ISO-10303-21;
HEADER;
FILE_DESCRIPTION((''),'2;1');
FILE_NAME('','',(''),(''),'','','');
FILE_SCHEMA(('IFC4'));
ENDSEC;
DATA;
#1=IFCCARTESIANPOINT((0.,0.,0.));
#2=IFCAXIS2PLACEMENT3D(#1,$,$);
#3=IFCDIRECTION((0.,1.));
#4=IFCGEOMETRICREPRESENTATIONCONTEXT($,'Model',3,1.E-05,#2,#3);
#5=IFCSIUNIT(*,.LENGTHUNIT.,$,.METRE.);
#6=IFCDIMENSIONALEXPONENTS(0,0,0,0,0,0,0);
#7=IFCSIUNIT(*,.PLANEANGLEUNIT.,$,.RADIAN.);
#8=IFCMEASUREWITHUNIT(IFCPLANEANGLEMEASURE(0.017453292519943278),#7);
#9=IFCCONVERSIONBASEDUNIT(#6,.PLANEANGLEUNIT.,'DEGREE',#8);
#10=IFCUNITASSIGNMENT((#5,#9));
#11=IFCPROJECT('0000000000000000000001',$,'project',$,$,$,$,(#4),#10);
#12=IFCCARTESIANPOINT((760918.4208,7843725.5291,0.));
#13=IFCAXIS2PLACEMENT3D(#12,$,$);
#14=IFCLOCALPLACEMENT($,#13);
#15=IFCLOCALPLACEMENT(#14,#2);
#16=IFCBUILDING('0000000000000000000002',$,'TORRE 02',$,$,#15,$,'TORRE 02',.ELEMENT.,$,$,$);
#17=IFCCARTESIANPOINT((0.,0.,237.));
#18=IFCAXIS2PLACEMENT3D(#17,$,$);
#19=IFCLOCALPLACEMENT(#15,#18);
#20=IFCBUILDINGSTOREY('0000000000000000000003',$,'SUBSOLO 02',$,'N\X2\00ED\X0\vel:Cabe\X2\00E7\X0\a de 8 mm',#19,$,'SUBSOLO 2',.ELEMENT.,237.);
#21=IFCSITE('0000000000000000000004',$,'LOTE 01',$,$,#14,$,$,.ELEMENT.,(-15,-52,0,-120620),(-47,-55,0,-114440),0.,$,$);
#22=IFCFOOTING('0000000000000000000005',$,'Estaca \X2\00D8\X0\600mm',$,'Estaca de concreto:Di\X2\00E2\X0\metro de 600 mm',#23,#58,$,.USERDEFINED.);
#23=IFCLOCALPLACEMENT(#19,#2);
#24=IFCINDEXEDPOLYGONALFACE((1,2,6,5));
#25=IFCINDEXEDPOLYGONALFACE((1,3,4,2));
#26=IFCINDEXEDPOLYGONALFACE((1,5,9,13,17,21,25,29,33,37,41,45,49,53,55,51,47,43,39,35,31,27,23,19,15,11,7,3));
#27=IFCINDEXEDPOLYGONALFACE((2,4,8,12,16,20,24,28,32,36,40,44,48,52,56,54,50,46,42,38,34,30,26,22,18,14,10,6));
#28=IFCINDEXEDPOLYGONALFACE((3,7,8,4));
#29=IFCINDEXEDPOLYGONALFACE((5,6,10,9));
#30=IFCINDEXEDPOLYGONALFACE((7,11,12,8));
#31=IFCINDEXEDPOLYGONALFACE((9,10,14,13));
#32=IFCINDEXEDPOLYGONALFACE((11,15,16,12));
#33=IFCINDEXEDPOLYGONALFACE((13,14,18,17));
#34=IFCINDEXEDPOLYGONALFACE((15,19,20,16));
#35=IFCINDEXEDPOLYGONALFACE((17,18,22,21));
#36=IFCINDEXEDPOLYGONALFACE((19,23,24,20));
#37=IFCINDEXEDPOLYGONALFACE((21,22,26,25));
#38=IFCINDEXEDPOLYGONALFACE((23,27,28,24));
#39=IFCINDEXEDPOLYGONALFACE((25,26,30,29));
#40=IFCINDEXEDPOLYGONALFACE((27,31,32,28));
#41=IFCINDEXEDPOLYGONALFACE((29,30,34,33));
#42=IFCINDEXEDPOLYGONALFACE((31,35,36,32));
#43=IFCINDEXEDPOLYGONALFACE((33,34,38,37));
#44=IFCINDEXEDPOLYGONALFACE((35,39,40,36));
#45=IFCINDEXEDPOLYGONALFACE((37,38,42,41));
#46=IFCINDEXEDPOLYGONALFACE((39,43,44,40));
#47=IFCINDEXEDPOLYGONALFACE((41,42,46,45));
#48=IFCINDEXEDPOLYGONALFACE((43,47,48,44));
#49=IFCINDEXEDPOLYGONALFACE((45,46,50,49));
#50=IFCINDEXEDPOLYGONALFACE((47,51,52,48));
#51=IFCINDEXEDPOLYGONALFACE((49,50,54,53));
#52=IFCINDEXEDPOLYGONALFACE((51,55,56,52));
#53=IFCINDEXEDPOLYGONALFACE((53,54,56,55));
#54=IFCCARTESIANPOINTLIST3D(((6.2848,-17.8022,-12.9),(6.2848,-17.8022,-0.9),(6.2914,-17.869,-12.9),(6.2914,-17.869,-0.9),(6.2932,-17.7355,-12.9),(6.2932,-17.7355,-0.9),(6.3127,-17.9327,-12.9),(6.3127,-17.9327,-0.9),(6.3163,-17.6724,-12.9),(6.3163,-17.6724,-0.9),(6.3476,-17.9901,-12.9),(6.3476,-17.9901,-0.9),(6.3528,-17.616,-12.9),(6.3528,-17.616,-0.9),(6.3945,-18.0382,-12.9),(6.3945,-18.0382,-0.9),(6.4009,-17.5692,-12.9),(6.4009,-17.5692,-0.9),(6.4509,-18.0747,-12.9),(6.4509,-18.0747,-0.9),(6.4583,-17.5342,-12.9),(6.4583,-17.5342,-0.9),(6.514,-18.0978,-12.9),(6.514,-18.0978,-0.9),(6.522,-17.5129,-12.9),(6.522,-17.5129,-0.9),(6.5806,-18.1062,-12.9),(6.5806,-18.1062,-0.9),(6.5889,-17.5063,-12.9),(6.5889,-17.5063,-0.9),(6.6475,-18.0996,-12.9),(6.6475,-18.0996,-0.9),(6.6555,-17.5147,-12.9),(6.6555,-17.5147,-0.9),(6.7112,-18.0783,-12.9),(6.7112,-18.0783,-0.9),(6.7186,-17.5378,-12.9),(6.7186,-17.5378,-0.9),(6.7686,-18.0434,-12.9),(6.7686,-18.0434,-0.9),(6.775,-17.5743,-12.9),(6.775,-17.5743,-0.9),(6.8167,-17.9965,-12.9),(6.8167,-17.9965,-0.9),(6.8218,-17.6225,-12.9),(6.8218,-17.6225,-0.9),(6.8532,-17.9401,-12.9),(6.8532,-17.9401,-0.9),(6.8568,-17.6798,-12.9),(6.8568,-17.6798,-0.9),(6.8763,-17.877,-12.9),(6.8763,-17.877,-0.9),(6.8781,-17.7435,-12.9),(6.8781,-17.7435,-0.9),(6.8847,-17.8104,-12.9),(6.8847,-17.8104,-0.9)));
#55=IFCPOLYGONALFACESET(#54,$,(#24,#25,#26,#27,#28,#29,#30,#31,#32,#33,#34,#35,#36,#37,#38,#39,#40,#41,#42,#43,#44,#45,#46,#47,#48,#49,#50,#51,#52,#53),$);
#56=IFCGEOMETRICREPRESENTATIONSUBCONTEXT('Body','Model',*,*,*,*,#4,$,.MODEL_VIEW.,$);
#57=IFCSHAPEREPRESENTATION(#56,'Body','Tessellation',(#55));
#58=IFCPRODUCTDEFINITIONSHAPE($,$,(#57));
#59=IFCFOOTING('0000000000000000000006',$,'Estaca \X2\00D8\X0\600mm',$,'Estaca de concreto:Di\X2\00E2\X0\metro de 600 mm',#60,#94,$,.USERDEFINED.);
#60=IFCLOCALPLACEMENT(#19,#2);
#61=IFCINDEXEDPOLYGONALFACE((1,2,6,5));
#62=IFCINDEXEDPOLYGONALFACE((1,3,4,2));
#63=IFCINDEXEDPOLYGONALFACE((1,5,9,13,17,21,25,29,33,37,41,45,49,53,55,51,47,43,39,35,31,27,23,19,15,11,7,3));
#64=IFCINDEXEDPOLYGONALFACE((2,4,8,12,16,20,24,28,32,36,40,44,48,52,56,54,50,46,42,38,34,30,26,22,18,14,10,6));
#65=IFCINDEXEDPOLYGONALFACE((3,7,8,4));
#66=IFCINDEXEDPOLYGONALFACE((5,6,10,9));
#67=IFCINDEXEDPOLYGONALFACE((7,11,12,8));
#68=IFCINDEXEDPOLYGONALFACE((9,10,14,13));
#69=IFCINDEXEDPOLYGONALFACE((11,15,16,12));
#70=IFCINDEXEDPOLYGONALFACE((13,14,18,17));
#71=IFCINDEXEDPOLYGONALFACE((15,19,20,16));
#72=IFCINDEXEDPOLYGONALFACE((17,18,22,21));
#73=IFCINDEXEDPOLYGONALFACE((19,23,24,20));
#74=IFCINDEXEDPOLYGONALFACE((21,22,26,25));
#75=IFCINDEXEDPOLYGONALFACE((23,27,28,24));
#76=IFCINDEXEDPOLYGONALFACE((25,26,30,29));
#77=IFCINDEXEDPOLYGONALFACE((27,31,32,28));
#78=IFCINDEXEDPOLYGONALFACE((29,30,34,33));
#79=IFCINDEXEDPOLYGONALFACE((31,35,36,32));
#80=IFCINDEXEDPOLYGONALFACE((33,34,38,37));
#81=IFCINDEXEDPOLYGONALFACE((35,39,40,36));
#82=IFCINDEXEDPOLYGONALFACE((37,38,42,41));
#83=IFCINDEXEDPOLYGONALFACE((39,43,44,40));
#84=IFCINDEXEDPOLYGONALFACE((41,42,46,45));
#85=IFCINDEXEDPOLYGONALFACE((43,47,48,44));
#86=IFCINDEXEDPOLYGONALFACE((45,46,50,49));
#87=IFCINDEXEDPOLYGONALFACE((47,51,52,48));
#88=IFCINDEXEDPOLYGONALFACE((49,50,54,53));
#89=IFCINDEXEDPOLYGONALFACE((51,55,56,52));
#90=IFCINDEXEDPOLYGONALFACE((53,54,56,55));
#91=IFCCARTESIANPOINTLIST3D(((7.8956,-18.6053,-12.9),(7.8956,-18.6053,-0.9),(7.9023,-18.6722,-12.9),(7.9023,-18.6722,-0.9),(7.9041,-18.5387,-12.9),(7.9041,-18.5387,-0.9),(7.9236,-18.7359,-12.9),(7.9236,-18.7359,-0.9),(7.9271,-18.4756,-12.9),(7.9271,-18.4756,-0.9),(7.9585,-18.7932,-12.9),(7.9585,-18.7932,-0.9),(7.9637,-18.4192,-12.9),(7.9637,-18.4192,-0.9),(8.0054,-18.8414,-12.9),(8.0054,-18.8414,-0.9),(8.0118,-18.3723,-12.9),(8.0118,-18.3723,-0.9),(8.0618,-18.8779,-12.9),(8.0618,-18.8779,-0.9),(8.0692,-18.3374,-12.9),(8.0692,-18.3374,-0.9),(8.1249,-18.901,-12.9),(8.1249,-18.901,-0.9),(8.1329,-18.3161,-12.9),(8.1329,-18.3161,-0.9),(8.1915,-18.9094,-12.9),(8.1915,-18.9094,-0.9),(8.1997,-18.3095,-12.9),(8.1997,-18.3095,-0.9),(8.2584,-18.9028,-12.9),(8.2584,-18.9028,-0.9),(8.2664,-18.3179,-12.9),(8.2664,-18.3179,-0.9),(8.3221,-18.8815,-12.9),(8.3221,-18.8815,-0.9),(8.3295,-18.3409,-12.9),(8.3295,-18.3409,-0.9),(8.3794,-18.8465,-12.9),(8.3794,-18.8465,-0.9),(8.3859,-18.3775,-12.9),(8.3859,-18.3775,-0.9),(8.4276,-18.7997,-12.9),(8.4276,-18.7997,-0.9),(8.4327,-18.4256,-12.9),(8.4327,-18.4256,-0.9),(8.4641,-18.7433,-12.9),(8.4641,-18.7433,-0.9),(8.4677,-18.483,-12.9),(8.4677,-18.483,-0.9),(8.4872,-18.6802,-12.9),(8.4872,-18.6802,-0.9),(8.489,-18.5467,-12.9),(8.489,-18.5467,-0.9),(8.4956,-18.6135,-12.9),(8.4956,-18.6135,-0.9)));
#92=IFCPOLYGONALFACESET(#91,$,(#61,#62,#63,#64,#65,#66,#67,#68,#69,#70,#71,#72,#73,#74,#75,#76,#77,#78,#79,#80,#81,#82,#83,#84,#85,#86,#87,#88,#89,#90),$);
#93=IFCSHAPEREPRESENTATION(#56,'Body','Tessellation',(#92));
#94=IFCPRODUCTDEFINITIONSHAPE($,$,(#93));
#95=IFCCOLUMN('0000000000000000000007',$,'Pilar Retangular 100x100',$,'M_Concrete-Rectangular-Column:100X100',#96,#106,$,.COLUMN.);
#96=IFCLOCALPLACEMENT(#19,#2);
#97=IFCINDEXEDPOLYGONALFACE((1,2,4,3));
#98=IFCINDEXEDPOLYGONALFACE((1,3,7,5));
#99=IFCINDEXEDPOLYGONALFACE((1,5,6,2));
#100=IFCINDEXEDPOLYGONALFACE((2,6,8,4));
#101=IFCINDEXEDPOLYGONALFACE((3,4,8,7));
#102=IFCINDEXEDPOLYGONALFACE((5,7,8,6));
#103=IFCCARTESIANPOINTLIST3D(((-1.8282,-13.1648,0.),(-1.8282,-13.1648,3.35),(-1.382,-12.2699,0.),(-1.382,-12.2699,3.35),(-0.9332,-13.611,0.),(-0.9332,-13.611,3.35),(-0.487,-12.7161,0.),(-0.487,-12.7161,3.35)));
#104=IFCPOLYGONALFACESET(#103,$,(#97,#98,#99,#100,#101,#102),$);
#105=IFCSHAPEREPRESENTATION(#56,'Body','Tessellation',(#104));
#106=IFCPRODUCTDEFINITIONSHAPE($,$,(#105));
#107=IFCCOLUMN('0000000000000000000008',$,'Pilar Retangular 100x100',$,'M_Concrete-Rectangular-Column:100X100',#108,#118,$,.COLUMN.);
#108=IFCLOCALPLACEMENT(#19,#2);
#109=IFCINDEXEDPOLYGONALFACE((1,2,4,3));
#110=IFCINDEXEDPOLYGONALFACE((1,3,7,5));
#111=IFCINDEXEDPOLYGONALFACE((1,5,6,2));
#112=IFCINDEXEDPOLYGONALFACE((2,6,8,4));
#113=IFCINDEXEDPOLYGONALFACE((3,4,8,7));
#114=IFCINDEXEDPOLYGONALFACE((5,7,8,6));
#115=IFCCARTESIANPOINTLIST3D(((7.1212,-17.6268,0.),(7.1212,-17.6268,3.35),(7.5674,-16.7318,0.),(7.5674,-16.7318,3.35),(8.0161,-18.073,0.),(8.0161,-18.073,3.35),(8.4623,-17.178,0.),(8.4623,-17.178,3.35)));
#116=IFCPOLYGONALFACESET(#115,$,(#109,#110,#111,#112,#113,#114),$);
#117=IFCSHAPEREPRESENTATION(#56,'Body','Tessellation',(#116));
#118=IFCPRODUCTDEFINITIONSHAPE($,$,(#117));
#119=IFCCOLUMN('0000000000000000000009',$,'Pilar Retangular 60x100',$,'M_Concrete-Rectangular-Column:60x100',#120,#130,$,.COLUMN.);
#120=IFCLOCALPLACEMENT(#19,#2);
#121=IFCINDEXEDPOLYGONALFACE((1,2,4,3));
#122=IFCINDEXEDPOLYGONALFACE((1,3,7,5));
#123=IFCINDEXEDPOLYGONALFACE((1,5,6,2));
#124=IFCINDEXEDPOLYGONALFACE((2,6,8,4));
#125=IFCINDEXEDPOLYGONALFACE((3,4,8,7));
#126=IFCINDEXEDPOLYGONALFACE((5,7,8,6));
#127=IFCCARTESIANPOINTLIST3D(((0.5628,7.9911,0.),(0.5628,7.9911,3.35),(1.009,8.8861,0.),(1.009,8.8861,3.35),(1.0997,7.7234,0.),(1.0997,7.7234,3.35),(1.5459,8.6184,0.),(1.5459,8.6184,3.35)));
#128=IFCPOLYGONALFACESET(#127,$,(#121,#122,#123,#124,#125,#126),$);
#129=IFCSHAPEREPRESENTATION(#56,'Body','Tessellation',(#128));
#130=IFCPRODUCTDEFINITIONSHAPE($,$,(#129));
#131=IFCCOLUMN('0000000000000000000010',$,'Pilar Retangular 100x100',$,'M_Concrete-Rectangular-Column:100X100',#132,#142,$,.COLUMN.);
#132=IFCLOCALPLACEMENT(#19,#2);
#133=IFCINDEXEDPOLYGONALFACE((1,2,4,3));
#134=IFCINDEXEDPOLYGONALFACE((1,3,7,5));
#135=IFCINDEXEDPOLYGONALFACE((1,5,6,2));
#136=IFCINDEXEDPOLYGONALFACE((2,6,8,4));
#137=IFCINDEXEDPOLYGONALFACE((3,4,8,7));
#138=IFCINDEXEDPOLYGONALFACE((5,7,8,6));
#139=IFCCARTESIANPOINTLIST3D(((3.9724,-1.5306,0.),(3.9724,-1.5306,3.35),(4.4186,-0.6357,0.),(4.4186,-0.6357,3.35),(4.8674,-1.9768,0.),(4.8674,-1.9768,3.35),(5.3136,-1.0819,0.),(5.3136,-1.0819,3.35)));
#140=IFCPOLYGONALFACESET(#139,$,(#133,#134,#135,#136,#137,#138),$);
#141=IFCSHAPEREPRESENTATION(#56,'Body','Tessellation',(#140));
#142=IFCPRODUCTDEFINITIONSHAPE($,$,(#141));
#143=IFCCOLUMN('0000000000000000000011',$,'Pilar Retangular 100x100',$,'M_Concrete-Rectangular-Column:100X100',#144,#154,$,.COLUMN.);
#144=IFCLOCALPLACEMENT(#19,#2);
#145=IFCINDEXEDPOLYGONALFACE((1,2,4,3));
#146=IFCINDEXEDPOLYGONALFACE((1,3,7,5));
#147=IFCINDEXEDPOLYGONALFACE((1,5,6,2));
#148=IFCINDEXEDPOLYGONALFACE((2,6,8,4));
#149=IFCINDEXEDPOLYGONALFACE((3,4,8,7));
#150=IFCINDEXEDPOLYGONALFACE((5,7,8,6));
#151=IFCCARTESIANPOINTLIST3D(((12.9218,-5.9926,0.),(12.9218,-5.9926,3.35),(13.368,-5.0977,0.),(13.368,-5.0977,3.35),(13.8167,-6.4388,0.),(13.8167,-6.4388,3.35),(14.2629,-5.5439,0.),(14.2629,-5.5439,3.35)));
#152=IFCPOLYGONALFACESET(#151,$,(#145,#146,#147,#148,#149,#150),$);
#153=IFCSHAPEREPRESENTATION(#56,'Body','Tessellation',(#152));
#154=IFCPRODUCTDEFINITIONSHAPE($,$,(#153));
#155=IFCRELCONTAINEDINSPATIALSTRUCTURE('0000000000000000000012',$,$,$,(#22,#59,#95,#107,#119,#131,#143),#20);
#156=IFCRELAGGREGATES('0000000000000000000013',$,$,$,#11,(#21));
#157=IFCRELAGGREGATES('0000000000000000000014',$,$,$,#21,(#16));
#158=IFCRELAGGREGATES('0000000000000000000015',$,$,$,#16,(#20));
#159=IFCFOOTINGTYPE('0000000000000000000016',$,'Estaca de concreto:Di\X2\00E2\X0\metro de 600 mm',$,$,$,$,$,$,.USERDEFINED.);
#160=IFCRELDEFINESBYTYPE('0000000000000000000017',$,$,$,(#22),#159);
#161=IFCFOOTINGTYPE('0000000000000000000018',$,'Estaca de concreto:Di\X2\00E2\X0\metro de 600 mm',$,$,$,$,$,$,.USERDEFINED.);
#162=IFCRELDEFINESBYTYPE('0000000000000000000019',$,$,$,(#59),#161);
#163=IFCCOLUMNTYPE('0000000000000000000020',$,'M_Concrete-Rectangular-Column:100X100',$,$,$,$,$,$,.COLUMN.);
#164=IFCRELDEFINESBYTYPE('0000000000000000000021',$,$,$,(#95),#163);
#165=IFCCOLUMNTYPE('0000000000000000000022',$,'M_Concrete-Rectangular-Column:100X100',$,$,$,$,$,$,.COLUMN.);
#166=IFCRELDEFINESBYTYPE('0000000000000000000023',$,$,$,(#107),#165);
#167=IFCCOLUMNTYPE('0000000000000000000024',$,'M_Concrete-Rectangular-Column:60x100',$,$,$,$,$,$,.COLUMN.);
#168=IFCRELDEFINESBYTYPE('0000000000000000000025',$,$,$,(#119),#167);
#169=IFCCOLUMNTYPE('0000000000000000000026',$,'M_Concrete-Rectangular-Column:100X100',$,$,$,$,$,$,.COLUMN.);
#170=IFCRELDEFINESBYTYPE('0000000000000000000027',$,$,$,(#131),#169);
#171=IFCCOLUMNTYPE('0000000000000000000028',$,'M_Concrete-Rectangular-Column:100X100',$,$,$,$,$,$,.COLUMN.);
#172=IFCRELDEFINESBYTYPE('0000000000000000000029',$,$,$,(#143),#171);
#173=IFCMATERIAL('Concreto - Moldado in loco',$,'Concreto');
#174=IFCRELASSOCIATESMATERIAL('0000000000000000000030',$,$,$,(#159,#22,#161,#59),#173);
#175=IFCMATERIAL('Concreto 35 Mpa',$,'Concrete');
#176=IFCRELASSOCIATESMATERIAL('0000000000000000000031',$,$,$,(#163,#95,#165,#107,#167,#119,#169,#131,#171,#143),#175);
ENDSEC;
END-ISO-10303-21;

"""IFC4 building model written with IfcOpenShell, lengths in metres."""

from ifc_helpers import new_model, entity, si_unit, converted_unit, direction, frame, origin, place, context, subcontext, project, spatial, arc, indexed_curve, outline, extrude, source, transform, mapped, material, type_object, type_shapes, element, save


model = new_model("IFC4")

# Units and contexts
model_context = context("Model", 3, precision=1e-05, world=origin(), true_north=direction((0.0, 1.0)))
body_context = subcontext(model_context, "Body", "Model", "MODEL_VIEW")
ifc_project = project(units=[si_unit("LENGTHUNIT", "METRE"), converted_unit("PLANEANGLEUNIT", "DEGREE", entity("IfcPlaneAngleMeasure", 0.017453292519943278), si_unit("PLANEANGLEUNIT", "RADIAN"), dimensions=[0, 0, 0, 0, 0, 0, 0])], contexts=[model_context])

# Site, building, storey
site_placement = place(None, frame((760918.4208, 7843725.5291, 0.0)))
site = spatial("IfcSite", under=ifc_project, at=site_placement, Name="LOTE 01", CompositionType="ELEMENT", RefLatitude=(-15, -52, 0, -120620), RefLongitude=(-47, -55, 0, -114440), RefElevation=0.0)
building_placement = place(site_placement, origin())
building = spatial("IfcBuilding", under=site, at=building_placement, Name="TORRE 02", LongName="TORRE 02", CompositionType="ELEMENT")
storey_placement = place(building_placement, frame((0.0, 0.0, 237.0)))
storey = spatial("IfcBuildingStorey", under=building, at=storey_placement, Name="SUBSOLO 02", ObjectType="Nível:Cabeça de 8 mm", LongName="SUBSOLO 2", CompositionType="ELEMENT", Elevation=237.0)

# Footings
ifc_material_1 = material(Name="Concreto - Moldado in loco", Category="Concreto")
placement = place(building_placement, frame((0.0, 0.0, 237.0)))
footing_type_1 = type_object("IfcFootingType", Name="Estaca de concreto:Diâmetro de 600 mm", PredefinedType="USERDEFINED", material=ifc_material_1)
shared_shape_1 = source(origin(), body_context, "Body", "SweptSolid", [
    extrude(outline(indexed_curve([(-0.3, 0.0), (0.0, -0.3), (0.3, 0.0), (0.0, 0.3)], segments=[arc(1, 2, 3), arc(3, 4, 1)], self_intersect=False)), frame((6.5847, -17.8063, -12.0), z_axis=(0.0, 0.0, 1.0), x_axis=(0.894934, -0.446198, 0.0)), (0.0, 0.0, 1.0), 12.0),
])
type_shapes(footing_type_1, [shared_shape_1])
footing_1_placement = place(placement, frame((0.0, 0.0, -0.9)))
element("IfcFooting", 1, at=footing_1_placement, inside=storey, type_object=footing_type_1, material=ifc_material_1, Name="Estaca Ø600mm", ObjectType="Estaca de concreto:Diâmetro de 600 mm", PredefinedType="USERDEFINED", context=body_context, shape_type="MappedRepresentation", body=[
    mapped(shared_shape_1, transform((0.0, 0.0, 0.0), scale=1.0)),
])
footing_type_2 = type_object("IfcFootingType", Name="Estaca de concreto:Diâmetro de 600 mm", PredefinedType="USERDEFINED", material=ifc_material_1)
shared_shape_2 = source(origin(), body_context, "Body", "SweptSolid", [
    extrude(outline(indexed_curve([(-0.3, 0.0), (0.0, -0.3), (0.3, 0.0), (0.0, 0.3)], segments=[arc(1, 2, 3), arc(3, 4, 1)], self_intersect=False)), frame((8.1956, -18.6094, -12.0), z_axis=(0.0, 0.0, 1.0), x_axis=(0.894934, -0.446198, 0.0)), (0.0, 0.0, 1.0), 12.0),
])
type_shapes(footing_type_2, [shared_shape_2])
footing_2_placement = place(placement, frame((0.0, 0.0, -0.9)))
element("IfcFooting", 2, at=footing_2_placement, inside=storey, type_object=footing_type_2, material=ifc_material_1, Name="Estaca Ø600mm", ObjectType="Estaca de concreto:Diâmetro de 600 mm", PredefinedType="USERDEFINED", context=body_context, shape_type="MappedRepresentation", body=[
    mapped(shared_shape_2, transform((0.0, 0.0, 0.0), scale=1.0)),
])

# Columns
ifc_material_2 = material(Name="Concreto 35 Mpa", Category="Concrete")
column_type_1 = type_object("IfcColumnType", Name="M_Concrete-Rectangular-Column:100X100", PredefinedType="COLUMN", material=ifc_material_2)
shared_shape_3 = source(origin(), body_context, "Body", "SweptSolid", [
    extrude(outline(indexed_curve([(-0.5, -0.5), (0.5, -0.5), (0.5, 0.5), (-0.5, 0.5), (-0.5, -0.5)], self_intersect=False)), frame((-1.1576, -12.9404, 237.0), z_axis=(0.0, 0.0, 1.0), x_axis=(-0.894934, 0.446198, 0.0)), (0.0, 0.0, 1.0), 3.35),
])
type_shapes(column_type_1, [shared_shape_3])
column_1_placement = place(placement, frame((0.0, 0.0, -237.0)))
element("IfcColumn", 3, at=column_1_placement, inside=storey, type_object=column_type_1, material=ifc_material_2, Name="Pilar Retangular 100x100", ObjectType="M_Concrete-Rectangular-Column:100X100", PredefinedType="COLUMN", context=body_context, shape_type="MappedRepresentation", body=[
    mapped(shared_shape_3, transform((0.0, 0.0, 0.0), scale=1.0)),
])
column_type_2 = type_object("IfcColumnType", Name="M_Concrete-Rectangular-Column:100X100", PredefinedType="COLUMN", material=ifc_material_2)
shared_shape_4 = source(origin(), body_context, "Body", "SweptSolid", [
    extrude(outline(indexed_curve([(-0.5, -0.5), (0.5, -0.5), (0.5, 0.5), (-0.5, 0.5), (-0.5, -0.5)], self_intersect=False)), frame((7.7918, -17.4024, 237.0), z_axis=(0.0, 0.0, 1.0), x_axis=(-0.894934, 0.446198, 0.0)), (0.0, 0.0, 1.0), 3.35),
])
type_shapes(column_type_2, [shared_shape_4])
column_2_placement = place(placement, frame((0.0, 0.0, -237.0)))
element("IfcColumn", 4, at=column_2_placement, inside=storey, type_object=column_type_2, material=ifc_material_2, Name="Pilar Retangular 100x100", ObjectType="M_Concrete-Rectangular-Column:100X100", PredefinedType="COLUMN", context=body_context, shape_type="MappedRepresentation", body=[
    mapped(shared_shape_4, transform((0.0, 0.0, 0.0), scale=1.0)),
])
column_type_3 = type_object("IfcColumnType", Name="M_Concrete-Rectangular-Column:60x100", PredefinedType="COLUMN", material=ifc_material_2)
shared_shape_5 = source(origin(), body_context, "Body", "SweptSolid", [
    extrude(outline(indexed_curve([(-1.675, -0.3), (1.675, -0.3), (1.675, 0.3), (-1.675, 0.3), (-1.675, -0.3)], self_intersect=False)), frame((0.8313, 7.8573, 238.675), z_axis=(0.446198, 0.894934, 0.0), x_axis=(0.0, 0.0, 1.0)), (0.0, 0.0, 1.0), 1.0),
])
type_shapes(column_type_3, [shared_shape_5])
column_3_placement = place(placement, frame((0.0, 0.0, -237.0)))
element("IfcColumn", 5, at=column_3_placement, inside=storey, type_object=column_type_3, material=ifc_material_2, Name="Pilar Retangular 60x100", ObjectType="M_Concrete-Rectangular-Column:60x100", PredefinedType="COLUMN", context=body_context, shape_type="MappedRepresentation", body=[
    mapped(shared_shape_5, transform((0.0, 0.0, 0.0), scale=1.0)),
])
column_type_4 = type_object("IfcColumnType", Name="M_Concrete-Rectangular-Column:100X100", PredefinedType="COLUMN", material=ifc_material_2)
shared_shape_6 = source(origin(), body_context, "Body", "SweptSolid", [
    extrude(outline(indexed_curve([(-0.5, -0.5), (0.5, -0.5), (0.5, 0.5), (-0.5, 0.5), (-0.5, -0.5)], self_intersect=False)), frame((4.643, -1.3063, 237.0), z_axis=(0.0, 0.0, 1.0), x_axis=(-0.894934, 0.446198, 0.0)), (0.0, 0.0, 1.0), 3.35),
])
type_shapes(column_type_4, [shared_shape_6])
column_4_placement = place(placement, frame((0.0, 0.0, -237.0)))
element("IfcColumn", 6, at=column_4_placement, inside=storey, type_object=column_type_4, material=ifc_material_2, Name="Pilar Retangular 100x100", ObjectType="M_Concrete-Rectangular-Column:100X100", PredefinedType="COLUMN", context=body_context, shape_type="MappedRepresentation", body=[
    mapped(shared_shape_6, transform((0.0, 0.0, 0.0), scale=1.0)),
])
column_type_5 = type_object("IfcColumnType", Name="M_Concrete-Rectangular-Column:100X100", PredefinedType="COLUMN", material=ifc_material_2)
shared_shape_7 = source(origin(), body_context, "Body", "SweptSolid", [
    extrude(outline(indexed_curve([(-0.5, -0.5), (0.5, -0.5), (0.5, 0.5), (-0.5, 0.5), (-0.5, -0.5)], self_intersect=False)), frame((13.5923, -5.7683, 237.0), z_axis=(0.0, 0.0, 1.0), x_axis=(-0.894934, 0.446198, 0.0)), (0.0, 0.0, 1.0), 3.35),
])
type_shapes(column_type_5, [shared_shape_7])
column_5_placement = place(placement, frame((0.0, 0.0, -237.0)))
element("IfcColumn", 7, at=column_5_placement, inside=storey, type_object=column_type_5, material=ifc_material_2, Name="Pilar Retangular 100x100", ObjectType="M_Concrete-Rectangular-Column:100X100", PredefinedType="COLUMN", context=body_context, shape_type="MappedRepresentation", body=[
    mapped(shared_shape_7, transform((0.0, 0.0, 0.0), scale=1.0)),
])

save(model, "model.ifc")
